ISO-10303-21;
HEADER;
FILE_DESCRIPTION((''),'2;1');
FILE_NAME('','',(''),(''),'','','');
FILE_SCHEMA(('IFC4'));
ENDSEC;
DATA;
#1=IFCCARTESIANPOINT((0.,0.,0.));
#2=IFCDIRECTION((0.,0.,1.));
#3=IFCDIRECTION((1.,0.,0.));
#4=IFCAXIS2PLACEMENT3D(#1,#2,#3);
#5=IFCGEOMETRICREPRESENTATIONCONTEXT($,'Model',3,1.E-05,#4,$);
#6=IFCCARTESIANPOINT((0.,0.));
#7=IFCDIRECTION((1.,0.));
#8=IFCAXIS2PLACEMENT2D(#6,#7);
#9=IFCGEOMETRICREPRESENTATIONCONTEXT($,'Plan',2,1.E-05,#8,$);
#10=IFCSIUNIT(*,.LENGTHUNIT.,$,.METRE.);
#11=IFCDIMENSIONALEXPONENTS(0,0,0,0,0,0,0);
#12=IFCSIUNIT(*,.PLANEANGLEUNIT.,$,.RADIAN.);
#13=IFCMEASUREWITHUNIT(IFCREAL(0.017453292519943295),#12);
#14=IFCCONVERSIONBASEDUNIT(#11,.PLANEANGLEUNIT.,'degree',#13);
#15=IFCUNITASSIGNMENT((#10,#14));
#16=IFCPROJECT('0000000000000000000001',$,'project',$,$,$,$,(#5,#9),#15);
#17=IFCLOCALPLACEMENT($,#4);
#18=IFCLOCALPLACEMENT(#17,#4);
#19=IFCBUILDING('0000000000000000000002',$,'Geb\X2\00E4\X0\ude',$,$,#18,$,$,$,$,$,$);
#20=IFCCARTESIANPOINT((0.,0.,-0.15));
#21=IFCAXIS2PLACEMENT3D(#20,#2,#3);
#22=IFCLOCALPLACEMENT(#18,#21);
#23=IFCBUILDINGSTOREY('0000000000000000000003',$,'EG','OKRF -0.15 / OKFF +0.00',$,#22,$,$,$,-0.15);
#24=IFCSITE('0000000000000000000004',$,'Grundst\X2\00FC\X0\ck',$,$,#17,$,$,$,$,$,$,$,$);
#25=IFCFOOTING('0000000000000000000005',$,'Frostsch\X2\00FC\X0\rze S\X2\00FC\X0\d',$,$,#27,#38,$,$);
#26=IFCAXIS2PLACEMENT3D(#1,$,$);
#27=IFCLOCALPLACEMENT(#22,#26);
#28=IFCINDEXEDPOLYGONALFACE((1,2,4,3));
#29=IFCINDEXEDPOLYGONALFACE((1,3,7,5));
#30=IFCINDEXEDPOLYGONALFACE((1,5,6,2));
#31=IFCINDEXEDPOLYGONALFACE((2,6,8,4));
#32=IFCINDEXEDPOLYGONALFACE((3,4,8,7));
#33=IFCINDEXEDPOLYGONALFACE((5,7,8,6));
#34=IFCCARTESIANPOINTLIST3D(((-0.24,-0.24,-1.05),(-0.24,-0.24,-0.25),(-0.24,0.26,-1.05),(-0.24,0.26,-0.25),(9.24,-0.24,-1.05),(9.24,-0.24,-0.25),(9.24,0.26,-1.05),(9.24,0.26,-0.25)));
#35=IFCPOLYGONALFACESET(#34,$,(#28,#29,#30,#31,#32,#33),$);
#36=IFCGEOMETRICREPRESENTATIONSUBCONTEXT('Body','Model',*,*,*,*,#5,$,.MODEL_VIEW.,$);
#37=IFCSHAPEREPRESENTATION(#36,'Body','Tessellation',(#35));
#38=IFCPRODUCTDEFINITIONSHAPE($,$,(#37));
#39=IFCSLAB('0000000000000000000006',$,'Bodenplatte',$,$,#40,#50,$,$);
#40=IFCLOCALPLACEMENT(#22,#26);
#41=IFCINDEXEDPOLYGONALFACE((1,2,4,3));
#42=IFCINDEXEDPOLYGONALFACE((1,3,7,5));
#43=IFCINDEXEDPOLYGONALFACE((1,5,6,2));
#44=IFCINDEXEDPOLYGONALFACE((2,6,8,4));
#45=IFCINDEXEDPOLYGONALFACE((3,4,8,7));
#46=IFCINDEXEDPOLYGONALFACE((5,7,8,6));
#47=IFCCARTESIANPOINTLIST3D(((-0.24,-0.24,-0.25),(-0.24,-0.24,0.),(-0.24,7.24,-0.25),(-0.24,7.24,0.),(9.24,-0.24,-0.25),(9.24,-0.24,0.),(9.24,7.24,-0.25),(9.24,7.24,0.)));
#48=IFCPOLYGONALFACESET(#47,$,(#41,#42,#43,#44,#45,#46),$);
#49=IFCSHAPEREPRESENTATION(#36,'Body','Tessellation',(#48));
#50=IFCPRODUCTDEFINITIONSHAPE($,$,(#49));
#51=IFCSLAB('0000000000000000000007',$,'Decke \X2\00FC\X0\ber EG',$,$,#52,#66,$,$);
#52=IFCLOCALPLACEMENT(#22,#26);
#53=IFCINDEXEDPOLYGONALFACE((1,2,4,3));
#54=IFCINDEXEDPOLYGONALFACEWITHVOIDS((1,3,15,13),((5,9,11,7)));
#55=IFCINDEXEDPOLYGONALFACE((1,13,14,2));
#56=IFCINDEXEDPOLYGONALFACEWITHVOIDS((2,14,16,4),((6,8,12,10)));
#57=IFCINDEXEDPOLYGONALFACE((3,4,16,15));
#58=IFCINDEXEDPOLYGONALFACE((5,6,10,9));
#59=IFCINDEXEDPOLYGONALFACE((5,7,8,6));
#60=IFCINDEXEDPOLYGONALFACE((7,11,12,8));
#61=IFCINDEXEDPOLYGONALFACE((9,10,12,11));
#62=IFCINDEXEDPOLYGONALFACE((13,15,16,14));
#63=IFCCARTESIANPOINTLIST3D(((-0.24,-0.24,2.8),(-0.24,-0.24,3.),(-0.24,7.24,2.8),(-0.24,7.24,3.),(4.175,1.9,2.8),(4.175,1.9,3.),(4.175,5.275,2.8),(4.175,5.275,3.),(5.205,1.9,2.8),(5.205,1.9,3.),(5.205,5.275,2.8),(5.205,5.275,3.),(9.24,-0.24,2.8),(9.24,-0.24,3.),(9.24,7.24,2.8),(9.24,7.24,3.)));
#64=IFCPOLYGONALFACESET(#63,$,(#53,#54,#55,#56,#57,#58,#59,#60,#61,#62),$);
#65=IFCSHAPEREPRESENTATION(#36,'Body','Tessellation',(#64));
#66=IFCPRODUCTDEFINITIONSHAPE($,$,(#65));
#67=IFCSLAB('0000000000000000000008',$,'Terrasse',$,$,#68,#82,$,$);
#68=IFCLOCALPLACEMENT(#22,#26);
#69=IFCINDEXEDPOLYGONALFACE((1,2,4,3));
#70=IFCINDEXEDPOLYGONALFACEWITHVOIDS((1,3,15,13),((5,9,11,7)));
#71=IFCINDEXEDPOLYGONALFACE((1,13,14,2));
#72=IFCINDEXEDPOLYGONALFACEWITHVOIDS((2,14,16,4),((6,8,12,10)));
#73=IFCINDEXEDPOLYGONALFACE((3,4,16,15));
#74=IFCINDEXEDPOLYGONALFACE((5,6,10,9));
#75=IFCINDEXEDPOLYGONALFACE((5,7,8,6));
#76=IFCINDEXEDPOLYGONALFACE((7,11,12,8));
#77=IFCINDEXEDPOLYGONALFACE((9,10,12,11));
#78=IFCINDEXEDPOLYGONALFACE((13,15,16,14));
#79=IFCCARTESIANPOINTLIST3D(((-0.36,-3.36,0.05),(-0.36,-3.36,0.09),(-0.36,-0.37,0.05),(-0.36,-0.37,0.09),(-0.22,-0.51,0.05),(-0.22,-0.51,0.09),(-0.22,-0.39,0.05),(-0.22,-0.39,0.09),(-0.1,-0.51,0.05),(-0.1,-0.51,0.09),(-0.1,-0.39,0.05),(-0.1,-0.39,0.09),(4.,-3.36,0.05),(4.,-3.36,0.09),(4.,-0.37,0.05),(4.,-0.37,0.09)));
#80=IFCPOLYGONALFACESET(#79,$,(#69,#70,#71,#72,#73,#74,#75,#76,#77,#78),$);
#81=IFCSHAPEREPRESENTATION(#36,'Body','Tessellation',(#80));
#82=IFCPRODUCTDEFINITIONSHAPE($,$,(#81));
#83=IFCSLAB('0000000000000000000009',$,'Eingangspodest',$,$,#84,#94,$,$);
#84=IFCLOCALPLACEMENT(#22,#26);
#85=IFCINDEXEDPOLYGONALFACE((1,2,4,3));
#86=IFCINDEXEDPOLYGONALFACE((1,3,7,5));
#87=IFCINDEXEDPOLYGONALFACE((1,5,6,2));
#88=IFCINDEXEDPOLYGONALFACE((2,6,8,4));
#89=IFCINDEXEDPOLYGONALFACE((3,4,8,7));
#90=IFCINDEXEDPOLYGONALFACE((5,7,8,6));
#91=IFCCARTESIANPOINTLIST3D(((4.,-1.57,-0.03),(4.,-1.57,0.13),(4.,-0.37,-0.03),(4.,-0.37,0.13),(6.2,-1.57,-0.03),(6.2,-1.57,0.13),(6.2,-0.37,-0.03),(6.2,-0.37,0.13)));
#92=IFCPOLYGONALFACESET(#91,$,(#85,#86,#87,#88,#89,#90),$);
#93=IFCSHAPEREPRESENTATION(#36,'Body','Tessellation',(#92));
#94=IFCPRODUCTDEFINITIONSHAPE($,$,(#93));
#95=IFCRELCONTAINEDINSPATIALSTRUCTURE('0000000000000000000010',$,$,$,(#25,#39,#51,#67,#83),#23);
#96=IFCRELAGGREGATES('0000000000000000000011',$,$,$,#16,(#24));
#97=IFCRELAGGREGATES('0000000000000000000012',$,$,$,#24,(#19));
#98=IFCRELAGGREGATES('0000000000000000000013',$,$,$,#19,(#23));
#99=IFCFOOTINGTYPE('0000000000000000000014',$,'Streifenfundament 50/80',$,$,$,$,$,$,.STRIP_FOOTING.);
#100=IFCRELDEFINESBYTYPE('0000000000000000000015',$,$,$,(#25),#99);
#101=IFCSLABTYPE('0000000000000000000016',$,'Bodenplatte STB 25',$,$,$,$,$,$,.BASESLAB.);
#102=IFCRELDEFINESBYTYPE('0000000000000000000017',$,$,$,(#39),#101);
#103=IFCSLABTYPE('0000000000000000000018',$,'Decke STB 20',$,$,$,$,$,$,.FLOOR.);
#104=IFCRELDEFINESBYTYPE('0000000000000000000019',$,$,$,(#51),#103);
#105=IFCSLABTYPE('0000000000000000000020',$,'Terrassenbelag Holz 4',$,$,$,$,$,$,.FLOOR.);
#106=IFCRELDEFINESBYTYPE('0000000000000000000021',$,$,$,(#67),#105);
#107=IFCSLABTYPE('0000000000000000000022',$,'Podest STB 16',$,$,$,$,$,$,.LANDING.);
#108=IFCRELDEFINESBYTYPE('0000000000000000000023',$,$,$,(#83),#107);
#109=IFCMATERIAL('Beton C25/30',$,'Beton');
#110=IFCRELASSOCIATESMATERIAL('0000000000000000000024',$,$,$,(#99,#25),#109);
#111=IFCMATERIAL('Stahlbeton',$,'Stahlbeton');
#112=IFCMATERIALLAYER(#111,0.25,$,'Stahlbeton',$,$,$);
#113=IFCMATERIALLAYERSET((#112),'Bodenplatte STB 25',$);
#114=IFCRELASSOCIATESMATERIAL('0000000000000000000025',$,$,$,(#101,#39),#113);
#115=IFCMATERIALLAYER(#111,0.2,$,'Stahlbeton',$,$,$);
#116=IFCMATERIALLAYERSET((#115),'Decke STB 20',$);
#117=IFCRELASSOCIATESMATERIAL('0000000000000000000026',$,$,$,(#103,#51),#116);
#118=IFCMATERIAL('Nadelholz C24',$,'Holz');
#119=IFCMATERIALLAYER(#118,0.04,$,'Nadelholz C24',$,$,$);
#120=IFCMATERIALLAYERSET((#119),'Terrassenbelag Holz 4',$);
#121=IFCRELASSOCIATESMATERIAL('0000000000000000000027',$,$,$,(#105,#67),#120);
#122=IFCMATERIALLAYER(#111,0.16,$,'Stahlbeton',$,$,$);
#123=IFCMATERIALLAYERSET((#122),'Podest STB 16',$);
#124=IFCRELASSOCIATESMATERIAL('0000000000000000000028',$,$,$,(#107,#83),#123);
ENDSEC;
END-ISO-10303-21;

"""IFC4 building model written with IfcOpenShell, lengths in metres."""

from ifc_helpers import new_model, entity, si_unit, converted_unit, frame, origin_with_axes, origin_2d_with_axis, place, context, subcontext, project, spatial, indexed_curve, rectangle, outline, extrude, material, layer, layer_set, layer_usage, material_profile, profile_set, profile_usage, type_object, element, save


model = new_model("IFC4")

# Units and contexts
model_context = context("Model", 3, precision=1e-05, world=origin_with_axes())
plan_context = context("Plan", 2, precision=1e-05, world=origin_2d_with_axis())
body_context_1 = subcontext(model_context, "Body", "Model", "MODEL_VIEW")
ifc_project = project(units=[si_unit("LENGTHUNIT", "METRE"), converted_unit("PLANEANGLEUNIT", "degree", entity("IfcReal", 0.017453292519943295), si_unit("PLANEANGLEUNIT", "RADIAN"), dimensions=[0, 0, 0, 0, 0, 0, 0])], contexts=[model_context, plan_context])

# Site, building, storey
site_placement = place(None, origin_with_axes())
site = spatial("IfcSite", under=ifc_project, at=site_placement, Name="Grundstück")
building_placement = place(site_placement, origin_with_axes())
building = spatial("IfcBuilding", under=site, at=building_placement, Name="Gebäude")
storey_placement = place(building_placement, frame((0.0, 0.0, -0.15), z_axis=(0.0, 0.0, 1.0), x_axis=(1.0, 0.0, 0.0)))
storey = spatial("IfcBuildingStorey", under=building, at=storey_placement, Name="EG", Description="OKRF -0.15 / OKFF +0.00", Elevation=-0.15)

# Footing
ifc_material_1 = material(Name="Beton C25/30", Category="Beton")
ifc_material_profile = material_profile(ifc_material_1, rectangle(XDim=0.5, YDim=0.8))
ifc_profile_set = profile_set([ifc_material_profile], Name="Streifenfundament 50/80")
ifc_profile_usage = profile_usage(ifc_profile_set)
footing_type = type_object("IfcFootingType", Name="Streifenfundament 50/80", PredefinedType="STRIP_FOOTING", material=ifc_profile_set)
footing_placement = place(storey_placement, frame((-0.24, 0.01, -0.65), z_axis=(1.0, 0.0, 0.0), x_axis=(0.0, 1.0, 0.0)))
element("IfcFooting", 1, at=footing_placement, inside=storey, type_object=footing_type, material=ifc_profile_usage, Name="Frostschürze Süd", context=body_context_1, shape_type="SweptSolid", body=[
    extrude(rectangle(XDim=0.5, YDim=0.8), origin_with_axes(), (0.0, 0.0, 1.0), 9.48),
])

# Slab
ifc_material_2 = material(Name="Stahlbeton", Category="Stahlbeton")
ifc_layer_1 = layer(ifc_material_2, 0.25, Name="Stahlbeton")
ifc_layer_set_1 = layer_set([ifc_layer_1], Name="Bodenplatte STB 25")
ifc_layer_usage_1 = layer_usage(ifc_layer_set_1, "AXIS3", "POSITIVE", 0.0)
slab_type_1 = type_object("IfcSlabType", Name="Bodenplatte STB 25", PredefinedType="BASESLAB", material=ifc_layer_set_1)
slab_1_placement = place(storey_placement, frame((0.0, 0.0, -0.25), z_axis=(0.0, 0.0, 1.0), x_axis=(1.0, 0.0, 0.0)))
element("IfcSlab", 2, at=slab_1_placement, inside=storey, type_object=slab_type_1, material=ifc_layer_usage_1, Name="Bodenplatte", context=body_context_1, shape_type="SweptSolid", body=[
    extrude(outline(indexed_curve([(-0.24, -0.24), (9.24, -0.24), (9.24, 7.24), (-0.24, 7.24)])), None, (0.0, 0.0, 1.0), 0.25),
])

# Slabs, openings
ifc_layer_2 = layer(ifc_material_2, 0.2, Name="Stahlbeton")
ifc_layer_set_2 = layer_set([ifc_layer_2], Name="Decke STB 20")
ifc_layer_usage_2 = layer_usage(ifc_layer_set_2, "AXIS3", "POSITIVE", 0.0)
slab_type_2 = type_object("IfcSlabType", Name="Decke STB 20", PredefinedType="FLOOR", material=ifc_layer_set_2)
slab_2_placement = place(storey_placement, frame((0.0, 0.0, 2.8), z_axis=(0.0, 0.0, 1.0), x_axis=(1.0, 0.0, 0.0)))
slab_2 = element("IfcSlab", 3, at=slab_2_placement, inside=storey, type_object=slab_type_2, material=ifc_layer_usage_2, Name="Decke über EG", context=body_context_1, shape_type="SweptSolid", body=[
    extrude(outline(indexed_curve([(-0.24, -0.24), (9.24, -0.24), (9.24, 7.24), (-0.24, 7.24)])), None, (0.0, 0.0, 1.0), 0.2),
])
opening_1_placement = place(slab_2_placement, frame((4.175, 1.9, -0.05), z_axis=(0.0, 0.0, 1.0), x_axis=(1.0, 0.0, 0.0)))
element("IfcOpeningElement", 4, at=opening_1_placement, cuts=slab_2, context=body_context_1, shape_type="SweptSolid", body=[
    extrude(outline(indexed_curve([(0.0, 0.0), (0.0, 3.375), (1.03, 3.375), (1.03, 0.0), (0.0, 0.0)], self_intersect=False)), origin_with_axes(), (0.0, 0.0, 1.0), 0.3),
])
ifc_material_3 = material(Name="Nadelholz C24", Category="Holz")
ifc_layer_3 = layer(ifc_material_3, 0.04, Name="Nadelholz C24")
ifc_layer_set_3 = layer_set([ifc_layer_3], Name="Terrassenbelag Holz 4")
ifc_layer_usage_3 = layer_usage(ifc_layer_set_3, "AXIS3", "POSITIVE", 0.0)
slab_type_3 = type_object("IfcSlabType", Name="Terrassenbelag Holz 4", PredefinedType="FLOOR", material=ifc_layer_set_3)
slab_3_placement = place(storey_placement, frame((0.0, 0.0, 0.05), z_axis=(0.0, 0.0, 1.0), x_axis=(1.0, 0.0, 0.0)))
slab_3 = element("IfcSlab", 5, at=slab_3_placement, inside=storey, type_object=slab_type_3, material=ifc_layer_usage_3, Name="Terrasse", context=body_context_1, shape_type="SweptSolid", body=[
    extrude(outline(indexed_curve([(-0.36, -3.36), (4.0, -3.36), (4.0, -0.37), (-0.36, -0.37)])), None, (0.0, 0.0, 1.0), 0.04),
])
opening_2_placement = place(slab_3_placement, frame((-0.22, -0.51, -0.05), z_axis=(0.0, 0.0, 1.0), x_axis=(1.0, 0.0, 0.0)))
element("IfcOpeningElement", 6, at=opening_2_placement, cuts=slab_3, context=body_context_1, shape_type="SweptSolid", body=[
    extrude(outline(indexed_curve([(0.0, 0.0), (0.0, 0.12), (0.12, 0.12), (0.12, 0.0), (0.0, 0.0)], self_intersect=False)), origin_with_axes(), (0.0, 0.0, 1.0), 0.14),
])

# Slab
ifc_layer_4 = layer(ifc_material_2, 0.16, Name="Stahlbeton")
ifc_layer_set_4 = layer_set([ifc_layer_4], Name="Podest STB 16")
ifc_layer_usage_4 = layer_usage(ifc_layer_set_4, "AXIS3", "POSITIVE", 0.0)
slab_type_4 = type_object("IfcSlabType", Name="Podest STB 16", PredefinedType="LANDING", material=ifc_layer_set_4)
slab_4_placement = place(storey_placement, frame((0.0, 0.0, -0.03), z_axis=(0.0, 0.0, 1.0), x_axis=(1.0, 0.0, 0.0)))
element("IfcSlab", 7, at=slab_4_placement, inside=storey, type_object=slab_type_4, material=ifc_layer_usage_4, Name="Eingangspodest", context=body_context_1, shape_type="SweptSolid", body=[
    extrude(outline(indexed_curve([(4.0, -1.57), (6.2, -1.57), (6.2, -0.37), (4.0, -0.37)])), None, (0.0, 0.0, 1.0), 0.16),
])

save(model, "model.ifc")
